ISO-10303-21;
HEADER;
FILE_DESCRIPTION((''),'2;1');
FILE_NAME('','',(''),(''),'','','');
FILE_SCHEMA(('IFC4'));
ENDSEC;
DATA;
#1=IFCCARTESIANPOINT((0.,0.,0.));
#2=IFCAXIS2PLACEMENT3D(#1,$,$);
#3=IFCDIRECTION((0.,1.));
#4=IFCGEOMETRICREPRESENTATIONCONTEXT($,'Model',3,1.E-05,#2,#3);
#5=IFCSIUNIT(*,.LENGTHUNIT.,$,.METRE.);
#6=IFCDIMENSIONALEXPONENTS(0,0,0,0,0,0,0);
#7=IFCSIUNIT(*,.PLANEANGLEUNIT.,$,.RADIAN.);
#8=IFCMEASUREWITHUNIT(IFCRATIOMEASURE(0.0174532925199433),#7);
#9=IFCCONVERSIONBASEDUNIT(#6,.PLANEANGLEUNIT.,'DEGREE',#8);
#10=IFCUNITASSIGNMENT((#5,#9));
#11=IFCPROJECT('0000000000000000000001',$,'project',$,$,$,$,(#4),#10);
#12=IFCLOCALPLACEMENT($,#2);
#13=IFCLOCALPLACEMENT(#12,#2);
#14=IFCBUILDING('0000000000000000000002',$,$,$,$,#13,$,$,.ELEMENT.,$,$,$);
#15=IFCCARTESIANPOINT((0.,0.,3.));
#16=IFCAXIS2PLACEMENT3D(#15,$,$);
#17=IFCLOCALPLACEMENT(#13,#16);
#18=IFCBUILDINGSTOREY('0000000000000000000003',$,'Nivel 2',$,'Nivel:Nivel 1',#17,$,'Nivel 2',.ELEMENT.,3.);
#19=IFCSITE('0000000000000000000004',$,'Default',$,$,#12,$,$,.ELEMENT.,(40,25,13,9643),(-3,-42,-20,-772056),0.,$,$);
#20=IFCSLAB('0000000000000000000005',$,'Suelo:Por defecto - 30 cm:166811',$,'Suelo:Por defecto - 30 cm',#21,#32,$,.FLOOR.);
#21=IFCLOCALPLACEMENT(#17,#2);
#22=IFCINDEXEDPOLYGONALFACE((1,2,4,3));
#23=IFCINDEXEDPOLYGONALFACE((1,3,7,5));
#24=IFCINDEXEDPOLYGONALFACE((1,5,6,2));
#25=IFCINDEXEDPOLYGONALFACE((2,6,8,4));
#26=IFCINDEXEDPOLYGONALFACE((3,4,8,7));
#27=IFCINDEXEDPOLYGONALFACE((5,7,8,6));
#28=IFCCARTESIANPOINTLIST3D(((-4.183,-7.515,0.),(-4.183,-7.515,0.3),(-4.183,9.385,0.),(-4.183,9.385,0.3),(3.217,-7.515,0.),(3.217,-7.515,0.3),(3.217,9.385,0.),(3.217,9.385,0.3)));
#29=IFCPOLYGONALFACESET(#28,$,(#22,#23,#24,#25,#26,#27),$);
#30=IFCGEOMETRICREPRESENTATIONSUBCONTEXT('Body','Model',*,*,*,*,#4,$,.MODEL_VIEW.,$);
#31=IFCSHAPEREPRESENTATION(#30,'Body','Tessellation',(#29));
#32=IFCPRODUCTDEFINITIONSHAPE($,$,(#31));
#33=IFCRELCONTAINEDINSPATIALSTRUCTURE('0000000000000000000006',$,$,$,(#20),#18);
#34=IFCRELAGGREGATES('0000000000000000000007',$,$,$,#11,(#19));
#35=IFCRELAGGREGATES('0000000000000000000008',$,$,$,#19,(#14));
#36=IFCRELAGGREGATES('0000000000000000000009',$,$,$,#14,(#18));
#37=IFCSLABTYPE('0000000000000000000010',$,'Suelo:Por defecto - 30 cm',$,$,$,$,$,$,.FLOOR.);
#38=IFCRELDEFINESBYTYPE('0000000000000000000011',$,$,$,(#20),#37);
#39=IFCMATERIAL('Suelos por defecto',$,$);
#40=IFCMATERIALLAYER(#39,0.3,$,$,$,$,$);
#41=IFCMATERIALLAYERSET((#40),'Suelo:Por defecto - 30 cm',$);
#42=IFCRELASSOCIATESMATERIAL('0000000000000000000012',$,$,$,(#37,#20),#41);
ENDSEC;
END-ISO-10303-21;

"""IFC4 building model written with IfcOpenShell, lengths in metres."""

from ifc_helpers import new_model, entity, si_unit, converted_unit, direction, frame, origin, origin_2d_with_axis, place, context, subcontext, project, spatial, rectangle, extrude, material, layer, layer_set, layer_usage, type_object, element, save


model = new_model("IFC4")

# Units and contexts
model_context = context("Model", 3, precision=1e-05, world=origin(), true_north=direction((0.0, 1.0)))
body_context = subcontext(model_context, "Body", "Model", "MODEL_VIEW")
ifc_project = project(units=[si_unit("LENGTHUNIT", "METRE"), converted_unit("PLANEANGLEUNIT", "DEGREE", entity("IfcRatioMeasure", 0.0174532925199433), si_unit("PLANEANGLEUNIT", "RADIAN"), dimensions=[0, 0, 0, 0, 0, 0, 0])], contexts=[model_context])

# Site, building, storey
site_placement = place(None, origin())
site = spatial("IfcSite", under=ifc_project, at=site_placement, Name="Default", CompositionType="ELEMENT", RefLatitude=(40, 25, 13, 9643), RefLongitude=(-3, -42, -20, -772056), RefElevation=0.0)
building_placement = place(site_placement, origin())
building = spatial("IfcBuilding", under=site, at=building_placement, CompositionType="ELEMENT")
storey_placement = place(building_placement, frame((0.0, 0.0, 3.0)))
storey = spatial("IfcBuildingStorey", under=building, at=storey_placement, Name="Nivel 2", ObjectType="Nivel:Nivel 1", LongName="Nivel 2", CompositionType="ELEMENT", Elevation=3.0)

# Slab
ifc_material = material(Name="Suelos por defecto")
ifc_layer = layer(ifc_material, 0.3)
ifc_layer_set = layer_set([ifc_layer], Name="Suelo:Por defecto - 30 cm")
ifc_layer_usage = layer_usage(ifc_layer_set, "AXIS3", "POSITIVE", 0.0)
slab_type = type_object("IfcSlabType", Name="Suelo:Por defecto - 30 cm", PredefinedType="FLOOR", material=ifc_layer_set)
slab_placement = place(storey_placement, origin())
element("IfcSlab", 1, at=slab_placement, inside=storey, type_object=slab_type, material=ifc_layer_usage, Name="Suelo:Por defecto - 30 cm:166811", ObjectType="Suelo:Por defecto - 30 cm", PredefinedType="FLOOR", context=body_context, shape_type="SweptSolid", body=[
    extrude(rectangle(XDim=16.9, YDim=7.4, at=origin_2d_with_axis()), frame((-0.483, 0.935, 0.3), z_axis=(0.0, 0.0, -1.0), x_axis=(0.0, 1.0, 0.0)), (0.0, 0.0, 1.0), 0.3),
])

save(model, "model.ifc")
